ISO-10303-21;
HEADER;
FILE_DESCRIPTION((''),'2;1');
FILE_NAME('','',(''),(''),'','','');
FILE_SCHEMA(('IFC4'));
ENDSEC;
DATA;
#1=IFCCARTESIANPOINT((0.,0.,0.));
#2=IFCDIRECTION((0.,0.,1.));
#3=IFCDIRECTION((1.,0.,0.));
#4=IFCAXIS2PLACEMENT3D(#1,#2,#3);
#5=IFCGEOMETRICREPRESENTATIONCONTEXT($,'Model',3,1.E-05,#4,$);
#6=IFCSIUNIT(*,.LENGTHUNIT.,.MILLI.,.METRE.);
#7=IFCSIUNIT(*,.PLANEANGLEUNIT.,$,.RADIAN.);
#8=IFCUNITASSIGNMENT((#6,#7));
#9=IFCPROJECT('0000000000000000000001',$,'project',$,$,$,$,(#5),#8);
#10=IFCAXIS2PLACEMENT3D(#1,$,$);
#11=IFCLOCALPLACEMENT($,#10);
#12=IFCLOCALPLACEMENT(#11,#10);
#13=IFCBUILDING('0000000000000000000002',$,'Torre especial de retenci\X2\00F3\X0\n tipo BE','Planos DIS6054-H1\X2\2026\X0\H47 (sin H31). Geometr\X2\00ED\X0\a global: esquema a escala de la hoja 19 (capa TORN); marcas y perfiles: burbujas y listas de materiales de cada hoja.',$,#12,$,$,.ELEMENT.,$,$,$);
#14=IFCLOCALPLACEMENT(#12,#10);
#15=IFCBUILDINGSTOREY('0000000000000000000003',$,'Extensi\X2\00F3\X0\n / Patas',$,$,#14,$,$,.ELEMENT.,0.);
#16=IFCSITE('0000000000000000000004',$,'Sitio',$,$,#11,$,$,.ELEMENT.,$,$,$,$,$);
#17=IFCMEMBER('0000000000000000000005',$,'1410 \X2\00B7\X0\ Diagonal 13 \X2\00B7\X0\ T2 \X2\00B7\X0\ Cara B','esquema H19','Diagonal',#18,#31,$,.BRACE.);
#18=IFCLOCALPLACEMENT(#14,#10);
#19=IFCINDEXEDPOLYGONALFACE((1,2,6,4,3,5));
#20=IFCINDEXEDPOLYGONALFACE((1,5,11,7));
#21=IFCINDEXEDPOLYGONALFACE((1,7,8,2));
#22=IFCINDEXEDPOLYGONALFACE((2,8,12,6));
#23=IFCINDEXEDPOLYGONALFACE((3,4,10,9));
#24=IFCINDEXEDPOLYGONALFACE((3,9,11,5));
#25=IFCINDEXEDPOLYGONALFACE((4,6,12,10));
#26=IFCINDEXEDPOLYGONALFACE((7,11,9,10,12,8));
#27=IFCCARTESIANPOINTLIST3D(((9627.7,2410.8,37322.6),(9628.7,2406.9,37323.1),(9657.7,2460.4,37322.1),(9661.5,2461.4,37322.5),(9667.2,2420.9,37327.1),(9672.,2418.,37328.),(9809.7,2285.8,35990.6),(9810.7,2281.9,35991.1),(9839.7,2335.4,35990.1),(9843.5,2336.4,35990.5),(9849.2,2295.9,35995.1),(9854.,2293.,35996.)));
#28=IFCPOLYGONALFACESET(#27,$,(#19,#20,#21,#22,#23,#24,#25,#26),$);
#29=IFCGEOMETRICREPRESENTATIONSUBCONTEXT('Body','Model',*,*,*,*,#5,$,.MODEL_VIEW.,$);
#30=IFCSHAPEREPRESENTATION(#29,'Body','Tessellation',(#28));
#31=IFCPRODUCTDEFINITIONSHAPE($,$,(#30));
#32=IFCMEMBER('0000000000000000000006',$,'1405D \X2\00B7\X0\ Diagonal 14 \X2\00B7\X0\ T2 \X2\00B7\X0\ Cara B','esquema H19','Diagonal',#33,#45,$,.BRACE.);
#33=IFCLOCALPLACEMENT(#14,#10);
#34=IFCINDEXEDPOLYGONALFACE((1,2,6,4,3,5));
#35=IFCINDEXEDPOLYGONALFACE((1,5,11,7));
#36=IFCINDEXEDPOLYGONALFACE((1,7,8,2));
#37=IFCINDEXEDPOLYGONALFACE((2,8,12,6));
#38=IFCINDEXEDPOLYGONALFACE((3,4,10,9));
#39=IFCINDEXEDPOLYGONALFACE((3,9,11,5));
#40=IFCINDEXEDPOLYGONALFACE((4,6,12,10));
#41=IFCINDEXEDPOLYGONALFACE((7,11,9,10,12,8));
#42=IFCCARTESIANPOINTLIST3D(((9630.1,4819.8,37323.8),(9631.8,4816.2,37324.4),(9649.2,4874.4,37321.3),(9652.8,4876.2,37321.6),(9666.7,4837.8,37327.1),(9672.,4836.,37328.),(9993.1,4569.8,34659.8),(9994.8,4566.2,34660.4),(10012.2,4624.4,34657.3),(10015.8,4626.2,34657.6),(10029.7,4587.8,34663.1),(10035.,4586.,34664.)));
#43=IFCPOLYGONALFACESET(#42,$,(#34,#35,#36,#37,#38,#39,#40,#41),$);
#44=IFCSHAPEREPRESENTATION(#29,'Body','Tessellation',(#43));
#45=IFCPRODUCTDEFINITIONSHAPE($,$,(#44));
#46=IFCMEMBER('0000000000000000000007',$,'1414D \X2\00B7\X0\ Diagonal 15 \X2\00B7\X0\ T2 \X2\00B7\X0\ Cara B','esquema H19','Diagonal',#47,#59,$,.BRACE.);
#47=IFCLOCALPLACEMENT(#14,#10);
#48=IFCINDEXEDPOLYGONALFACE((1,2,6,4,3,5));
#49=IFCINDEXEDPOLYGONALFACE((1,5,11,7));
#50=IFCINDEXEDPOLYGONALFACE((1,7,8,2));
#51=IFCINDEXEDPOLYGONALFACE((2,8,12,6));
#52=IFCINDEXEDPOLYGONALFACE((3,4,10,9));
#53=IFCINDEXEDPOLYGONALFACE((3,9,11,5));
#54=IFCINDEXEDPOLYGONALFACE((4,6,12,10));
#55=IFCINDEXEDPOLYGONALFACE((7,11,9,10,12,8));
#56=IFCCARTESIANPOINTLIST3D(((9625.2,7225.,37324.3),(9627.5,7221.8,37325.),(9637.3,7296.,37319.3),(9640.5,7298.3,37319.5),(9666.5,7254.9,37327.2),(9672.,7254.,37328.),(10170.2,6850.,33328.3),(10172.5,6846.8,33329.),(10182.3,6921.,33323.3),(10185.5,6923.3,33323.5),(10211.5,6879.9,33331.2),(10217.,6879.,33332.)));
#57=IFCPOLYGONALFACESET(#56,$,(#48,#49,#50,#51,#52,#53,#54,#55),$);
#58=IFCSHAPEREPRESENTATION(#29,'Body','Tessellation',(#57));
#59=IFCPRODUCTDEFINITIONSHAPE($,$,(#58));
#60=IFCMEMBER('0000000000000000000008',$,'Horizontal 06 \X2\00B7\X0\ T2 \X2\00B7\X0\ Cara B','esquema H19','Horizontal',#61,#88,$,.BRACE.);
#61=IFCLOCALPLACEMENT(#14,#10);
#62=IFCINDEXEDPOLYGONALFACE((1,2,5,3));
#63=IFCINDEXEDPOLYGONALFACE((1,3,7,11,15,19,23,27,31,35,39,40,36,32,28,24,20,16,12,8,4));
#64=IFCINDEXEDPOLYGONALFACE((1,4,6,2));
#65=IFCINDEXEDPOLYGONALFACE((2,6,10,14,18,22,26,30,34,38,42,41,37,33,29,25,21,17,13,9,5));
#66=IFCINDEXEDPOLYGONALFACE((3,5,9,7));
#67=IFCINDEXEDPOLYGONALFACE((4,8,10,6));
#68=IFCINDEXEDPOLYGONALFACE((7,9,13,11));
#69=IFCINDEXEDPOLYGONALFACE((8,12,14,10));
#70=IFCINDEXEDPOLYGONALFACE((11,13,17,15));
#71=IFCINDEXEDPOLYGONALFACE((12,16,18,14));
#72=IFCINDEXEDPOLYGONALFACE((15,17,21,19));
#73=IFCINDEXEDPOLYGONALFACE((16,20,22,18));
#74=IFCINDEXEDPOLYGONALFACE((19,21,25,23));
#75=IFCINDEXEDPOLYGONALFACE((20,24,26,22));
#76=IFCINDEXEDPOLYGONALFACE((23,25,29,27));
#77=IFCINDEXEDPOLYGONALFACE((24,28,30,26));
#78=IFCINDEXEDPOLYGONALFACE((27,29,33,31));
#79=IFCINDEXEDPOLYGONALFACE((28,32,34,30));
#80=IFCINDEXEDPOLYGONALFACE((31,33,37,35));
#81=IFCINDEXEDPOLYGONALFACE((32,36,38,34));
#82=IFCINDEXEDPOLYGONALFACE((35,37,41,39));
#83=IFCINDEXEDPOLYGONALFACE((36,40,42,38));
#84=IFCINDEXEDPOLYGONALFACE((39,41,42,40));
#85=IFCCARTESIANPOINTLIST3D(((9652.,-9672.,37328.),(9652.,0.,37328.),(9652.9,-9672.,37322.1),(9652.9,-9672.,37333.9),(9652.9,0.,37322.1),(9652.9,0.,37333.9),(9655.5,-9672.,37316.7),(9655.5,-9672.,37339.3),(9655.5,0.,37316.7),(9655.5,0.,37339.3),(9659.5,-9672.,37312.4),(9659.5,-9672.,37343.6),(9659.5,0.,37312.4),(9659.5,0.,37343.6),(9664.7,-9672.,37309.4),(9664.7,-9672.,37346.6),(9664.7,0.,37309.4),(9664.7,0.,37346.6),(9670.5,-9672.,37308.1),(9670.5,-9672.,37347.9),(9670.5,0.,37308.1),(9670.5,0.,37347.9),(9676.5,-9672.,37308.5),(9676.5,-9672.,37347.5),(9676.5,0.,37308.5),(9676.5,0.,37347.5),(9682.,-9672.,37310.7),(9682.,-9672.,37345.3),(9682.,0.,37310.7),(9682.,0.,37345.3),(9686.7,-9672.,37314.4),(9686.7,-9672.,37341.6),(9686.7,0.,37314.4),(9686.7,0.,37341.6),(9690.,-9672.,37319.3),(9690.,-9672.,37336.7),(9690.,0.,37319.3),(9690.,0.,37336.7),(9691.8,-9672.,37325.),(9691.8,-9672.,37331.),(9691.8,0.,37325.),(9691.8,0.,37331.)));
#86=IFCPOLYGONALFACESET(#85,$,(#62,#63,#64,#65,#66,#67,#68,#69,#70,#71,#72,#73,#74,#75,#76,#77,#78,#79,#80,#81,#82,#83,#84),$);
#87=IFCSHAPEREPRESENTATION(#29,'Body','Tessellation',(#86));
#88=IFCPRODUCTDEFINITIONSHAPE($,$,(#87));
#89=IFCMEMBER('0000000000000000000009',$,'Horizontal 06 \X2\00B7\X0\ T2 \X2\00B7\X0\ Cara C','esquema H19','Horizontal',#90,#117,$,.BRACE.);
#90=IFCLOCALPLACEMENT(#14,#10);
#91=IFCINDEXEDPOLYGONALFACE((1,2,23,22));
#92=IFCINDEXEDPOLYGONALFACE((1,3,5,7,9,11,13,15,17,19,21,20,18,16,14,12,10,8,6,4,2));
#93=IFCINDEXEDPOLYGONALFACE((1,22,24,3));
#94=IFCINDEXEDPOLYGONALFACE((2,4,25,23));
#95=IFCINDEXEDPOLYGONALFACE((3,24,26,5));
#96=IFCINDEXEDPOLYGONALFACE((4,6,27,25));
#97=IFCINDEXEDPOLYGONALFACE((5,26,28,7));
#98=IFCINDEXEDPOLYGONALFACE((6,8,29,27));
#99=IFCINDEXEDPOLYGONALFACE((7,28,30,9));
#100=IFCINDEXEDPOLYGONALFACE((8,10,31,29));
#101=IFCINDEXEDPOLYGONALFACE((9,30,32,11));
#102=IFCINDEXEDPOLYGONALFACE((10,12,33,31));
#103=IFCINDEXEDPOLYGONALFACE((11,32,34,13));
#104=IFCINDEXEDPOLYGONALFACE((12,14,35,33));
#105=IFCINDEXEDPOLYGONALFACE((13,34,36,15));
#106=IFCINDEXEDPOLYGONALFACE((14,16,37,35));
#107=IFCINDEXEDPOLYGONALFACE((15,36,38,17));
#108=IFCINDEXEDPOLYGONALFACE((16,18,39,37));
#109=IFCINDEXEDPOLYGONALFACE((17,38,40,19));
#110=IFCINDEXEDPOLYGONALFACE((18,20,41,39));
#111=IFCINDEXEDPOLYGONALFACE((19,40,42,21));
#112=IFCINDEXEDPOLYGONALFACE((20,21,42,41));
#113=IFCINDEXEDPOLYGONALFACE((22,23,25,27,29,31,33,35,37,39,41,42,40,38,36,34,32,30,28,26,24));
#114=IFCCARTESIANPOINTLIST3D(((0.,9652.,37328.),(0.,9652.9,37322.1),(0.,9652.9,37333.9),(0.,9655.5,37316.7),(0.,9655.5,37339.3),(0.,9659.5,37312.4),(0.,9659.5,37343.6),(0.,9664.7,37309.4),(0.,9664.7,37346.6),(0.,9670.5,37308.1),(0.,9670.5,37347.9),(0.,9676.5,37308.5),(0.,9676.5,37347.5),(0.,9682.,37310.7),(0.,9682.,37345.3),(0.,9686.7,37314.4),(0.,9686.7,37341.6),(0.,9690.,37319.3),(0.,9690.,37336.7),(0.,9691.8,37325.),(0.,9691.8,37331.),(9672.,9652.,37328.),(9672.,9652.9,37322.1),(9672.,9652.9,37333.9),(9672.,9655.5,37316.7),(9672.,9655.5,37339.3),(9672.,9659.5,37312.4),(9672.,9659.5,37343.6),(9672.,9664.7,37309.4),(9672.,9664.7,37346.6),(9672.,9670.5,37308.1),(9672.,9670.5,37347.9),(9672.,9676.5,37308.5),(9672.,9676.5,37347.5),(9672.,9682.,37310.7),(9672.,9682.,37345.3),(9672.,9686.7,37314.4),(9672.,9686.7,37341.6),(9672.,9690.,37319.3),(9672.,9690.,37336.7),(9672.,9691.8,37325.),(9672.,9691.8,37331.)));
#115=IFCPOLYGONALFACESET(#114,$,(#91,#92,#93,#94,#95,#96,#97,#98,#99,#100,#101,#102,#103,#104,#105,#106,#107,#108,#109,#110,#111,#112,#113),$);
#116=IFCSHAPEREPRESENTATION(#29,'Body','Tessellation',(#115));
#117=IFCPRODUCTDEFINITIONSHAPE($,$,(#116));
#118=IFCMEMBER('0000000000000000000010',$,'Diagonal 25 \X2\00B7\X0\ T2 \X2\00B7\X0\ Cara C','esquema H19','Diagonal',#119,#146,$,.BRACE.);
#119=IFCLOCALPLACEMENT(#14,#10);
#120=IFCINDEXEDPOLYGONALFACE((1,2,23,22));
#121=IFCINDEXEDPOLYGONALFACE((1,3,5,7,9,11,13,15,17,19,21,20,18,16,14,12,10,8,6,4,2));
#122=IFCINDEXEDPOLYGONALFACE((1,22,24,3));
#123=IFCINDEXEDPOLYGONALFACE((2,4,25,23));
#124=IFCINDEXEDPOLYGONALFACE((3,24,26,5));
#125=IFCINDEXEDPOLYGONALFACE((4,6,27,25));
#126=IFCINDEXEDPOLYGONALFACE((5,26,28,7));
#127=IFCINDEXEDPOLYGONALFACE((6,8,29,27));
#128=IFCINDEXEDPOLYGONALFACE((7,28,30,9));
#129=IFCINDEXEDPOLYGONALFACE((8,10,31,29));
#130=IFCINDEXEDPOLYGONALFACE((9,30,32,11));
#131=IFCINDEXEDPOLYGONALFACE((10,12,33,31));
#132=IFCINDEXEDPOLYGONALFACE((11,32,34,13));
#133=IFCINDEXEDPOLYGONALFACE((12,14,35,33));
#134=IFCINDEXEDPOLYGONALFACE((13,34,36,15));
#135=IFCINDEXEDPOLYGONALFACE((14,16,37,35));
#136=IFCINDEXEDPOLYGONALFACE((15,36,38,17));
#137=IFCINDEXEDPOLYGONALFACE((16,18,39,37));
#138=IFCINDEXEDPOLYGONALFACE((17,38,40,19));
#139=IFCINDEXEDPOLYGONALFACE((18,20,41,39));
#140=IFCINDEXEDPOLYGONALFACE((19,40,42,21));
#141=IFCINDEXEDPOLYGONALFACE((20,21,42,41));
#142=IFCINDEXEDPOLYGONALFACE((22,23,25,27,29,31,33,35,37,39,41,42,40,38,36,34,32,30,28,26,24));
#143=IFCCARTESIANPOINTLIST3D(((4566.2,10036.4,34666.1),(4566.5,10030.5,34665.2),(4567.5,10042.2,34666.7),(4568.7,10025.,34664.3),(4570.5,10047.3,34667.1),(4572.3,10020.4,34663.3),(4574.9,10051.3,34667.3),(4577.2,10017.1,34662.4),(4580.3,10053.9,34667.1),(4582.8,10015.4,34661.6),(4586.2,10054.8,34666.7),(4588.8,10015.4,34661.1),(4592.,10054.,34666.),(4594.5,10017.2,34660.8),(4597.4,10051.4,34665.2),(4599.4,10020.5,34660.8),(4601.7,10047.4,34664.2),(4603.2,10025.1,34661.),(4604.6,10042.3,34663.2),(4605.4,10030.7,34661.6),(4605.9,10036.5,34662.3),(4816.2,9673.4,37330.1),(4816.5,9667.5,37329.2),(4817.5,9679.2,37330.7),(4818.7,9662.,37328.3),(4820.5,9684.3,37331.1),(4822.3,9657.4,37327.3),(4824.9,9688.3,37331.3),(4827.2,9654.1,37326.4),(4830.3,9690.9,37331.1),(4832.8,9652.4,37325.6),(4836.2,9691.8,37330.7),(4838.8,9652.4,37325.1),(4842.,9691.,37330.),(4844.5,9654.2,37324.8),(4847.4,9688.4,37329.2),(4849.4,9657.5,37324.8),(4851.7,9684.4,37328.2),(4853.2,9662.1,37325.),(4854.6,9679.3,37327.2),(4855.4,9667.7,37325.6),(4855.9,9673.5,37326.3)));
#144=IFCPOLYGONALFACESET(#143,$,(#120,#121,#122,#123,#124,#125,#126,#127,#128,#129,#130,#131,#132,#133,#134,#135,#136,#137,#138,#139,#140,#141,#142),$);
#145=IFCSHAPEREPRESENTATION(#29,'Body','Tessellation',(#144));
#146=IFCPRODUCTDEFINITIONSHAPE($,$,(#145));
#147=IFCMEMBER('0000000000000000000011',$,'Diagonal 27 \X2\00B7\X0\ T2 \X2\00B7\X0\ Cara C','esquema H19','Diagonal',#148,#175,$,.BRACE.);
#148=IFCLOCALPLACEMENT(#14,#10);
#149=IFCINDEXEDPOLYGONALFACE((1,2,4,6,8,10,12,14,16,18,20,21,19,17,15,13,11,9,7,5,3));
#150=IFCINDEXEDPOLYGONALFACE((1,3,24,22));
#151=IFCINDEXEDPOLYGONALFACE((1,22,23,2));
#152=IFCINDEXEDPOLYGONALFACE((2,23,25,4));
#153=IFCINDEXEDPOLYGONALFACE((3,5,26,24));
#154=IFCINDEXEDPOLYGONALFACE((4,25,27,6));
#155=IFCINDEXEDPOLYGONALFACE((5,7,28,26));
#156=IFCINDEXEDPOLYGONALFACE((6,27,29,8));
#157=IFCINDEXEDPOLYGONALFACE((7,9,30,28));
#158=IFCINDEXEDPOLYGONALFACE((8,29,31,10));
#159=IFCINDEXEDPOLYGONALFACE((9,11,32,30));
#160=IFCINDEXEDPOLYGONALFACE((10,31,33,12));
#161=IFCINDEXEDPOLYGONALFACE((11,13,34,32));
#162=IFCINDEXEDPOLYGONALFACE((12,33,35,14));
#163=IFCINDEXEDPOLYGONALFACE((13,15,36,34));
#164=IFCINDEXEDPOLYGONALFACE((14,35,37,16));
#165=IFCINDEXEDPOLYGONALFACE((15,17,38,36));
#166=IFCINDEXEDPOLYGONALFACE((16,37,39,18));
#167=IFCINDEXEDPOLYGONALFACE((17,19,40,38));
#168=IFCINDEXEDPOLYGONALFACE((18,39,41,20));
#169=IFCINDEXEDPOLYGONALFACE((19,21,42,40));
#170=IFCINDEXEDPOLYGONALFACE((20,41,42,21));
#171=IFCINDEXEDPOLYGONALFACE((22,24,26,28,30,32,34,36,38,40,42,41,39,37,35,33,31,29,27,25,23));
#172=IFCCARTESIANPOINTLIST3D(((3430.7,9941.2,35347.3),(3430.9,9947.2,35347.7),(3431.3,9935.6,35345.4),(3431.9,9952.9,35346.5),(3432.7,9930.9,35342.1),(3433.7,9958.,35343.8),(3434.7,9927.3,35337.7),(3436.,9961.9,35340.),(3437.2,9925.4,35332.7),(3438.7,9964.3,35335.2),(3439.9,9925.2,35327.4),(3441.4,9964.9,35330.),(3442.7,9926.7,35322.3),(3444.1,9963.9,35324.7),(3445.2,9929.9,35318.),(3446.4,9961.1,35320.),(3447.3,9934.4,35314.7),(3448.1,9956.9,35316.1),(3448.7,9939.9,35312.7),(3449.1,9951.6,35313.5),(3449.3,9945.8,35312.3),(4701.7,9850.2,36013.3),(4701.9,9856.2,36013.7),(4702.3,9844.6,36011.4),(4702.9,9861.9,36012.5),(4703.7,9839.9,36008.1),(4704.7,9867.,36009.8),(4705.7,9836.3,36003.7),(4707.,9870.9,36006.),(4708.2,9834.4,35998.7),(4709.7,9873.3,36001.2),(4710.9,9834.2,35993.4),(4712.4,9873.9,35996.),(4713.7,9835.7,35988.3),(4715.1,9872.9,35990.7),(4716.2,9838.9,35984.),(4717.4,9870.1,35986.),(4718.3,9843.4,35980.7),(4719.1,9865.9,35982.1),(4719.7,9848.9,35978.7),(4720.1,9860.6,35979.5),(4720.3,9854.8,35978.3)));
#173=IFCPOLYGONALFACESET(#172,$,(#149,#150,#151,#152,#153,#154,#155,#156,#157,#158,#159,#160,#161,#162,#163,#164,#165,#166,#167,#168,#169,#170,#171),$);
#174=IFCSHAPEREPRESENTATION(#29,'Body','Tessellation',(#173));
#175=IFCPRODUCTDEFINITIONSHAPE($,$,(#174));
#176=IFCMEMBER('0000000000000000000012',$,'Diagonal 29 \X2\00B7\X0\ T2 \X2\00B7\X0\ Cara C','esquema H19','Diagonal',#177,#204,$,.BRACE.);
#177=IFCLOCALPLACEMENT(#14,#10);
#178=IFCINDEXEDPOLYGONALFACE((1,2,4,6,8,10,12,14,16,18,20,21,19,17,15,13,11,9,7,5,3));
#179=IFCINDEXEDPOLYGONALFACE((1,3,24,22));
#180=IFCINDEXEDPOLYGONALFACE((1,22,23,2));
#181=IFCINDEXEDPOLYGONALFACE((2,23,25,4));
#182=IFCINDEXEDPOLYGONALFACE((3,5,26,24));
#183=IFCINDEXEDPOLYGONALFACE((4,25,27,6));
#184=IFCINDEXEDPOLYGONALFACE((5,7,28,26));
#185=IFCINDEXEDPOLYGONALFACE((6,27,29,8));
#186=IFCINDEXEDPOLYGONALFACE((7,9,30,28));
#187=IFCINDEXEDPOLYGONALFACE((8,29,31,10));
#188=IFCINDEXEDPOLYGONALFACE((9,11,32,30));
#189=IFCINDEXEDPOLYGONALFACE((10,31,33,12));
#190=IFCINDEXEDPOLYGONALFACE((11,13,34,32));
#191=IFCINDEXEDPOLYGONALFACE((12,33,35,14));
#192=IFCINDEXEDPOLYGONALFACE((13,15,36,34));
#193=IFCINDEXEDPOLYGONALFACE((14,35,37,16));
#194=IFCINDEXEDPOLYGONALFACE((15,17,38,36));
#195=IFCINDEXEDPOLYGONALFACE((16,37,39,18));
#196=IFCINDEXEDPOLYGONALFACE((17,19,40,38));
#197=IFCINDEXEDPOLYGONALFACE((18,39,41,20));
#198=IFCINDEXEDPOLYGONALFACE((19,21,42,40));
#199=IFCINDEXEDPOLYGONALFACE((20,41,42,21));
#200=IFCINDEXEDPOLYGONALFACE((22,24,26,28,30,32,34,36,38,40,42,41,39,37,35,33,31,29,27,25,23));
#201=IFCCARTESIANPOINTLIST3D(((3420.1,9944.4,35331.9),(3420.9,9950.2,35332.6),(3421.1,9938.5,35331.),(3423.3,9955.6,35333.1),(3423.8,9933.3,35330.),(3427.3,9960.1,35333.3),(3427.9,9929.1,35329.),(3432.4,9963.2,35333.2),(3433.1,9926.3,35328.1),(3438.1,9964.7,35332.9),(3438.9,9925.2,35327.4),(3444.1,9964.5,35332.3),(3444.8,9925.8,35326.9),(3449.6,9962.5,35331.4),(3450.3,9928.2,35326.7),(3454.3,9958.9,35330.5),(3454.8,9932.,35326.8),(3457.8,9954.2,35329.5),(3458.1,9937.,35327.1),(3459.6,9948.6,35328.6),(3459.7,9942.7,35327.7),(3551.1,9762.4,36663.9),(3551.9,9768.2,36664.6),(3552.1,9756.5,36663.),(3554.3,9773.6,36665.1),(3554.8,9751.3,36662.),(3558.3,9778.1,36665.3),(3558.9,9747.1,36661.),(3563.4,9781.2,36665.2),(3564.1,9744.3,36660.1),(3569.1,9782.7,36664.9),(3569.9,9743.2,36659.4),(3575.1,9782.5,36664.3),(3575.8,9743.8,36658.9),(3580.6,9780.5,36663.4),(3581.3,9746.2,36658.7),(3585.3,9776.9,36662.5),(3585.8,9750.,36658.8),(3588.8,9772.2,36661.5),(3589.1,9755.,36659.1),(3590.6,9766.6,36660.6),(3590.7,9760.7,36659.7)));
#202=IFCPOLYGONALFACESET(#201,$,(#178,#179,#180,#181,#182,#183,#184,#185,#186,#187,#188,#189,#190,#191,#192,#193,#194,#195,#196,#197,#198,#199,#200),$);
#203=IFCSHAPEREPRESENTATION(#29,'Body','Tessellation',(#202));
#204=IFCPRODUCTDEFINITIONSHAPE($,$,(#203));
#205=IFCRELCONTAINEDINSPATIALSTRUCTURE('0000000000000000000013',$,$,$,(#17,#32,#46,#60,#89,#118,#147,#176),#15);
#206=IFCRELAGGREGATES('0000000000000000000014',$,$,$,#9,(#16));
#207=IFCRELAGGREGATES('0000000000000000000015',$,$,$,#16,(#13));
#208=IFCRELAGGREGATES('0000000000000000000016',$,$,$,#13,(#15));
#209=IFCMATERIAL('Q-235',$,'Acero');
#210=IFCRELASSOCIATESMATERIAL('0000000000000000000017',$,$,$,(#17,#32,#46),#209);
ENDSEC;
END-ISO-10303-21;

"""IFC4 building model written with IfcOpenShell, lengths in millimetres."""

from ifc_helpers import new_model, si_unit, frame, frame_2d, origin, origin_with_axes, place, context, subcontext, project, spatial, circle, l_section, extrude, material, element, save


model = new_model("IFC4")

# Units and contexts
model_context = context("Model", 3, precision=1e-05, world=origin_with_axes())
body_context = subcontext(model_context, "Body", "Model", "MODEL_VIEW")
ifc_project = project(units=[si_unit("LENGTHUNIT", "METRE", prefix="MILLI"), si_unit("PLANEANGLEUNIT", "RADIAN")], contexts=[model_context])

# Site, building, storey
site_placement = place(None, origin())
site = spatial("IfcSite", under=ifc_project, at=site_placement, Name="Sitio", CompositionType="ELEMENT")
building_placement = place(site_placement, origin())
building = spatial("IfcBuilding", under=site, at=building_placement, Name="Torre especial de retención tipo BE", Description="Planos DIS6054-H1…H47 (sin H31). Geometría global: esquema a escala de la hoja 19 (capa TORN); marcas y perfiles: burbujas y listas de materiales de cada hoja.", CompositionType="ELEMENT")
storey_placement = place(building_placement, origin())
storey = spatial("IfcBuildingStorey", under=building, at=storey_placement, Name="Extensión / Patas", CompositionType="ELEMENT", Elevation=0.0)

# Members
ifc_material = material(Name="Q-235", Category="Acero")
member_1_placement = place(storey_placement, frame((9672.0, 2418.0, 37328.0), z_axis=(0.134797, -0.092581, -0.986539), x_axis=(-0.963143, -0.246135, -0.108502)))
element("IfcMember", 1, at=member_1_placement, inside=storey, material=ifc_material, Name="1410 · Diagonal 13 · T2 · Cara B", Description="esquema H19", ObjectType="Diagonal", PredefinedType="BRACE", context=body_context, shape_type="SweptSolid", body=[
    extrude(l_section(Depth=45.0, Width=45.0, Thickness=4.0, at=frame_2d((22.5, 22.5))), None, (0.0, 0.0, 1.0), 1350.2),
])
member_2_placement = place(storey_placement, frame((9672.0, 4836.0, 37328.0), z_axis=(0.134434, -0.092585, -0.986588), x_axis=(-0.894217, -0.440332, -0.080525)))
element("IfcMember", 2, at=member_2_placement, inside=storey, material=ifc_material, Name="1405D · Diagonal 14 · T2 · Cara B", Description="esquema H19", ObjectType="Diagonal", PredefinedType="BRACE", context=body_context, shape_type="SweptSolid", body=[
    extrude(l_section(Depth=45.0, Width=45.0, Thickness=4.0, at=frame_2d((22.5, 22.5))), None, (0.0, 0.0, 1.0), 2700.2),
])
member_3_placement = place(storey_placement, frame((9672.0, 7254.0, 37328.0), z_axis=(0.134555, -0.092584, -0.986571), x_axis=(-0.808884, -0.585354, -0.055389)))
element("IfcMember", 3, at=member_3_placement, inside=storey, material=ifc_material, Name="1414D · Diagonal 15 · T2 · Cara B", Description="esquema H19", ObjectType="Diagonal", PredefinedType="BRACE", context=body_context, shape_type="SweptSolid", body=[
    extrude(l_section(Depth=55.0, Width=55.0, Thickness=4.0, at=frame_2d((27.5, 27.5))), None, (0.0, 0.0, 1.0), 4050.4),
])
for number, where, z_axis, x_axis, name in (
    (4, (9672.0, 0.0, 37328.0), (0.0, -1.0, 0.0), (-1.0, 0.0, 0.0), "Horizontal 06 · T2 · Cara B"),
    (5, (0.0, 9672.0, 37328.0), (1.0, 0.0, 0.0), (0.0, -1.0, 0.0), "Horizontal 06 · T2 · Cara C"),
):
    element("IfcMember", number, at=place(storey_placement, frame(where, z_axis=z_axis, x_axis=x_axis)), inside=storey, Name=name, Description="esquema H19", ObjectType="Horizontal", PredefinedType="BRACE", context=body_context, shape_type="SweptSolid", body=[
        extrude(circle(Radius=20.0), None, (0.0, 0.0, 1.0), 9672.0),
    ])
member_4_placement = place(storey_placement, frame((4836.0, 9672.0, 37328.0), z_axis=(-0.092585, 0.134434, -0.986588), x_axis=(-0.440332, -0.894217, -0.080525)))
element("IfcMember", 6, at=member_4_placement, inside=storey, Name="Diagonal 25 · T2 · Cara C", Description="esquema H19", ObjectType="Diagonal", PredefinedType="BRACE", context=body_context, shape_type="SweptSolid", body=[
    extrude(circle(Radius=20.0), None, (0.0, 0.0, 1.0), 2700.2),
])
member_5_placement = place(storey_placement, frame((3440.0, 9945.0, 35330.0), z_axis=(0.883987, -0.063291, 0.463207), x_axis=(-0.140479, -0.980966, 0.134055)))
element("IfcMember", 7, at=member_5_placement, inside=storey, Name="Diagonal 27 · T2 · Cara C", Description="esquema H19", ObjectType="Diagonal", PredefinedType="BRACE", context=body_context, shape_type="SweptSolid", body=[
    extrude(circle(Radius=20.0), None, (0.0, 0.0, 1.0), 1437.8),
])
member_6_placement = place(storey_placement, frame((3571.0, 9763.0, 36662.0), z_axis=(-0.096984, 0.134741, -0.986123), x_axis=(-0.345872, -0.933606, -0.093549)))
element("IfcMember", 8, at=member_6_placement, inside=storey, Name="Diagonal 29 · T2 · Cara C", Description="esquema H19", ObjectType="Diagonal", PredefinedType="BRACE", context=body_context, shape_type="SweptSolid", body=[
    extrude(circle(Radius=20.0), None, (0.0, 0.0, 1.0), 1350.7),
])

save(model, "model.ifc")
